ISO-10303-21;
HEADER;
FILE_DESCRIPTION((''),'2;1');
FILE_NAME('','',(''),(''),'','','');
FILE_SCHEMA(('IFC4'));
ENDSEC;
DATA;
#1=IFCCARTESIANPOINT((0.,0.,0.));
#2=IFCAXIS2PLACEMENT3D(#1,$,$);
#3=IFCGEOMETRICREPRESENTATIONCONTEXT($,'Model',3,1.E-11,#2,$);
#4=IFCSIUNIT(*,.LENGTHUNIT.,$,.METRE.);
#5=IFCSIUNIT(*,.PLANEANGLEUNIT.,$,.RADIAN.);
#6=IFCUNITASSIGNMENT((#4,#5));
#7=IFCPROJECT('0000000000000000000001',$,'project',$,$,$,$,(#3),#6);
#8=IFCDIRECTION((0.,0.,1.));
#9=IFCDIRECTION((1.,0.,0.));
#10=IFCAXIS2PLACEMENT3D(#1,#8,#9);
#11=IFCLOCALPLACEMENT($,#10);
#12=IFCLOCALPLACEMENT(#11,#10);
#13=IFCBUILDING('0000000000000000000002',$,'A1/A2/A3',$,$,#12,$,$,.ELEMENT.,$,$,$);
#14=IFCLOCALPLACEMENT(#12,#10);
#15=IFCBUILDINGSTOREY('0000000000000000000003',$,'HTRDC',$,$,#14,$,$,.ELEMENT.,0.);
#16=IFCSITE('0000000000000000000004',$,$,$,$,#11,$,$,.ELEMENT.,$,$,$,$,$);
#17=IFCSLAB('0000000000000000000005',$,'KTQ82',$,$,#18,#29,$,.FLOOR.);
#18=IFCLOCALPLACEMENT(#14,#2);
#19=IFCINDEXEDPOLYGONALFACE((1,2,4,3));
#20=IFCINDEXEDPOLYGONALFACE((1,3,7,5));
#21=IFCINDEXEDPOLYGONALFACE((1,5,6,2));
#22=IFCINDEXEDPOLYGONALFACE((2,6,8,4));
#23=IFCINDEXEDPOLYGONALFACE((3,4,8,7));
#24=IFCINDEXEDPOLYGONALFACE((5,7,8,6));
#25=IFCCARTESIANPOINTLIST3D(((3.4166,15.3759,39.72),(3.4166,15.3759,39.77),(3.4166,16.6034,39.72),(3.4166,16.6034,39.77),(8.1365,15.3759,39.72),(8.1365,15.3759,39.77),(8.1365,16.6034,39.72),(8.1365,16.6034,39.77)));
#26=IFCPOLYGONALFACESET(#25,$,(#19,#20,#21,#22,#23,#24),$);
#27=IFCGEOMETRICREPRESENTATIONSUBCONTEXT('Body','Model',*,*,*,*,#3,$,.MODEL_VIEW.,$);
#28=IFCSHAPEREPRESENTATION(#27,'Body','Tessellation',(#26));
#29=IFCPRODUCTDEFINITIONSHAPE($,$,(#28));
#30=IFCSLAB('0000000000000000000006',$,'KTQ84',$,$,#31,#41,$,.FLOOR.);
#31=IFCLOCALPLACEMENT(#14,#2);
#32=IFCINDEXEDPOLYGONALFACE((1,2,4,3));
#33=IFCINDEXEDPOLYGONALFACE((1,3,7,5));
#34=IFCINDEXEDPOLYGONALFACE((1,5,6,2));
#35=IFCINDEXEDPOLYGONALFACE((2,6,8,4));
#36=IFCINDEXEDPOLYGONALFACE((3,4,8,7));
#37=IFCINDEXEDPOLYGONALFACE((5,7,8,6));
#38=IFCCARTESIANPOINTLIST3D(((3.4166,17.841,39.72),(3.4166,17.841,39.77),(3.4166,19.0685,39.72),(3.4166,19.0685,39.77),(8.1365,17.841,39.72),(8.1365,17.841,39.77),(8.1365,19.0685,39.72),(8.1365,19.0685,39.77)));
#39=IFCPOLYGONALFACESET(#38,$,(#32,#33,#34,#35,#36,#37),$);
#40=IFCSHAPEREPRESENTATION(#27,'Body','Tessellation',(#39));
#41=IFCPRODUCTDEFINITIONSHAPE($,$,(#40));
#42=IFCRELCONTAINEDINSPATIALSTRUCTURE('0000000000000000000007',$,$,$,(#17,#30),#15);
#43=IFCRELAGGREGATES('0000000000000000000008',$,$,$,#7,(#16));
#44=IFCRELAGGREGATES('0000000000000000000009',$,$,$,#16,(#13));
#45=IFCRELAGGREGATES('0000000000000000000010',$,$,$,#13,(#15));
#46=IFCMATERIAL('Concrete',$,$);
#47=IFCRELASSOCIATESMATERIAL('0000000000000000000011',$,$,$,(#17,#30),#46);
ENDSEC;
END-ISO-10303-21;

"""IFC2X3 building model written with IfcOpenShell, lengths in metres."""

from ifc_helpers import new_model, si_unit, frame, origin, origin_with_axes, place, context, subcontext, project, spatial, polyline, outline, extrude, material, element, save


model = new_model("IFC2X3")

# Units and contexts
model_context = context("Model", 3, precision=1e-11, world=origin())
body_context = subcontext(model_context, "Body", "Model", "MODEL_VIEW")
ifc_project = project(units=[si_unit("LENGTHUNIT", "METRE"), si_unit("PLANEANGLEUNIT", "RADIAN")], contexts=[model_context])

# Site, building, storey
site_placement = place(None, origin_with_axes())
site = spatial("IfcSite", under=ifc_project, at=site_placement, CompositionType="ELEMENT")
building_placement = place(site_placement, origin_with_axes())
building = spatial("IfcBuilding", under=site, at=building_placement, Name="A1/A2/A3", CompositionType="ELEMENT")
storey_placement = place(building_placement, origin_with_axes())
storey = spatial("IfcBuildingStorey", under=building, at=storey_placement, Name="HTRDC", CompositionType="ELEMENT", Elevation=0.0)

# Shared definitions
ifc_material = material(Name="Concrete")

# Slab
for number, where, z_axis, x_axis, name in (
    (1, (3.4166, 15.3759, 39.72), (0.0, 0.0, 1.0), (1.0, 0.0, 0.0), "KTQ82"),
):
    element("IfcSlab", number, at=place(storey_placement, frame(where, z_axis=z_axis, x_axis=x_axis)), inside=storey, material=ifc_material, Name=name, PredefinedType="FLOOR", context=body_context, shape_type="SweptSolid", body=[
        extrude(outline(polyline([(0.0, 0.0), (0.0, -4.72), (1.2275, -4.72), (1.2275, 0.0), (0.0, 0.0)])), frame((0.0, 0.0, 0.0), z_axis=(0.0, 0.0, 1.0), x_axis=(0.0, 1.0, 0.0)), (0.0, 0.0, 1.0), 0.05),
    ])

# Slab
slab_1_placement = place(storey_placement, frame((3.4166, 17.841, 39.72), z_axis=(0.0, 0.0, 1.0), x_axis=(1.0, 0.0, 0.0)))
element("IfcSlab", 2, at=slab_1_placement, inside=storey, material=ifc_material, Name="KTQ84", PredefinedType="FLOOR", context=body_context, shape_type="SweptSolid", body=[
    extrude(outline(polyline([(0.0, 0.0), (0.0, -4.72), (1.2275, -4.72), (1.2275, 0.0), (0.0, 0.0)])), frame((0.0, 0.0, 0.0), z_axis=(0.0, 0.0, 1.0), x_axis=(0.0, 1.0, 0.0)), (0.0, 0.0, 1.0), 0.05),
])

save(model, "model.ifc")
